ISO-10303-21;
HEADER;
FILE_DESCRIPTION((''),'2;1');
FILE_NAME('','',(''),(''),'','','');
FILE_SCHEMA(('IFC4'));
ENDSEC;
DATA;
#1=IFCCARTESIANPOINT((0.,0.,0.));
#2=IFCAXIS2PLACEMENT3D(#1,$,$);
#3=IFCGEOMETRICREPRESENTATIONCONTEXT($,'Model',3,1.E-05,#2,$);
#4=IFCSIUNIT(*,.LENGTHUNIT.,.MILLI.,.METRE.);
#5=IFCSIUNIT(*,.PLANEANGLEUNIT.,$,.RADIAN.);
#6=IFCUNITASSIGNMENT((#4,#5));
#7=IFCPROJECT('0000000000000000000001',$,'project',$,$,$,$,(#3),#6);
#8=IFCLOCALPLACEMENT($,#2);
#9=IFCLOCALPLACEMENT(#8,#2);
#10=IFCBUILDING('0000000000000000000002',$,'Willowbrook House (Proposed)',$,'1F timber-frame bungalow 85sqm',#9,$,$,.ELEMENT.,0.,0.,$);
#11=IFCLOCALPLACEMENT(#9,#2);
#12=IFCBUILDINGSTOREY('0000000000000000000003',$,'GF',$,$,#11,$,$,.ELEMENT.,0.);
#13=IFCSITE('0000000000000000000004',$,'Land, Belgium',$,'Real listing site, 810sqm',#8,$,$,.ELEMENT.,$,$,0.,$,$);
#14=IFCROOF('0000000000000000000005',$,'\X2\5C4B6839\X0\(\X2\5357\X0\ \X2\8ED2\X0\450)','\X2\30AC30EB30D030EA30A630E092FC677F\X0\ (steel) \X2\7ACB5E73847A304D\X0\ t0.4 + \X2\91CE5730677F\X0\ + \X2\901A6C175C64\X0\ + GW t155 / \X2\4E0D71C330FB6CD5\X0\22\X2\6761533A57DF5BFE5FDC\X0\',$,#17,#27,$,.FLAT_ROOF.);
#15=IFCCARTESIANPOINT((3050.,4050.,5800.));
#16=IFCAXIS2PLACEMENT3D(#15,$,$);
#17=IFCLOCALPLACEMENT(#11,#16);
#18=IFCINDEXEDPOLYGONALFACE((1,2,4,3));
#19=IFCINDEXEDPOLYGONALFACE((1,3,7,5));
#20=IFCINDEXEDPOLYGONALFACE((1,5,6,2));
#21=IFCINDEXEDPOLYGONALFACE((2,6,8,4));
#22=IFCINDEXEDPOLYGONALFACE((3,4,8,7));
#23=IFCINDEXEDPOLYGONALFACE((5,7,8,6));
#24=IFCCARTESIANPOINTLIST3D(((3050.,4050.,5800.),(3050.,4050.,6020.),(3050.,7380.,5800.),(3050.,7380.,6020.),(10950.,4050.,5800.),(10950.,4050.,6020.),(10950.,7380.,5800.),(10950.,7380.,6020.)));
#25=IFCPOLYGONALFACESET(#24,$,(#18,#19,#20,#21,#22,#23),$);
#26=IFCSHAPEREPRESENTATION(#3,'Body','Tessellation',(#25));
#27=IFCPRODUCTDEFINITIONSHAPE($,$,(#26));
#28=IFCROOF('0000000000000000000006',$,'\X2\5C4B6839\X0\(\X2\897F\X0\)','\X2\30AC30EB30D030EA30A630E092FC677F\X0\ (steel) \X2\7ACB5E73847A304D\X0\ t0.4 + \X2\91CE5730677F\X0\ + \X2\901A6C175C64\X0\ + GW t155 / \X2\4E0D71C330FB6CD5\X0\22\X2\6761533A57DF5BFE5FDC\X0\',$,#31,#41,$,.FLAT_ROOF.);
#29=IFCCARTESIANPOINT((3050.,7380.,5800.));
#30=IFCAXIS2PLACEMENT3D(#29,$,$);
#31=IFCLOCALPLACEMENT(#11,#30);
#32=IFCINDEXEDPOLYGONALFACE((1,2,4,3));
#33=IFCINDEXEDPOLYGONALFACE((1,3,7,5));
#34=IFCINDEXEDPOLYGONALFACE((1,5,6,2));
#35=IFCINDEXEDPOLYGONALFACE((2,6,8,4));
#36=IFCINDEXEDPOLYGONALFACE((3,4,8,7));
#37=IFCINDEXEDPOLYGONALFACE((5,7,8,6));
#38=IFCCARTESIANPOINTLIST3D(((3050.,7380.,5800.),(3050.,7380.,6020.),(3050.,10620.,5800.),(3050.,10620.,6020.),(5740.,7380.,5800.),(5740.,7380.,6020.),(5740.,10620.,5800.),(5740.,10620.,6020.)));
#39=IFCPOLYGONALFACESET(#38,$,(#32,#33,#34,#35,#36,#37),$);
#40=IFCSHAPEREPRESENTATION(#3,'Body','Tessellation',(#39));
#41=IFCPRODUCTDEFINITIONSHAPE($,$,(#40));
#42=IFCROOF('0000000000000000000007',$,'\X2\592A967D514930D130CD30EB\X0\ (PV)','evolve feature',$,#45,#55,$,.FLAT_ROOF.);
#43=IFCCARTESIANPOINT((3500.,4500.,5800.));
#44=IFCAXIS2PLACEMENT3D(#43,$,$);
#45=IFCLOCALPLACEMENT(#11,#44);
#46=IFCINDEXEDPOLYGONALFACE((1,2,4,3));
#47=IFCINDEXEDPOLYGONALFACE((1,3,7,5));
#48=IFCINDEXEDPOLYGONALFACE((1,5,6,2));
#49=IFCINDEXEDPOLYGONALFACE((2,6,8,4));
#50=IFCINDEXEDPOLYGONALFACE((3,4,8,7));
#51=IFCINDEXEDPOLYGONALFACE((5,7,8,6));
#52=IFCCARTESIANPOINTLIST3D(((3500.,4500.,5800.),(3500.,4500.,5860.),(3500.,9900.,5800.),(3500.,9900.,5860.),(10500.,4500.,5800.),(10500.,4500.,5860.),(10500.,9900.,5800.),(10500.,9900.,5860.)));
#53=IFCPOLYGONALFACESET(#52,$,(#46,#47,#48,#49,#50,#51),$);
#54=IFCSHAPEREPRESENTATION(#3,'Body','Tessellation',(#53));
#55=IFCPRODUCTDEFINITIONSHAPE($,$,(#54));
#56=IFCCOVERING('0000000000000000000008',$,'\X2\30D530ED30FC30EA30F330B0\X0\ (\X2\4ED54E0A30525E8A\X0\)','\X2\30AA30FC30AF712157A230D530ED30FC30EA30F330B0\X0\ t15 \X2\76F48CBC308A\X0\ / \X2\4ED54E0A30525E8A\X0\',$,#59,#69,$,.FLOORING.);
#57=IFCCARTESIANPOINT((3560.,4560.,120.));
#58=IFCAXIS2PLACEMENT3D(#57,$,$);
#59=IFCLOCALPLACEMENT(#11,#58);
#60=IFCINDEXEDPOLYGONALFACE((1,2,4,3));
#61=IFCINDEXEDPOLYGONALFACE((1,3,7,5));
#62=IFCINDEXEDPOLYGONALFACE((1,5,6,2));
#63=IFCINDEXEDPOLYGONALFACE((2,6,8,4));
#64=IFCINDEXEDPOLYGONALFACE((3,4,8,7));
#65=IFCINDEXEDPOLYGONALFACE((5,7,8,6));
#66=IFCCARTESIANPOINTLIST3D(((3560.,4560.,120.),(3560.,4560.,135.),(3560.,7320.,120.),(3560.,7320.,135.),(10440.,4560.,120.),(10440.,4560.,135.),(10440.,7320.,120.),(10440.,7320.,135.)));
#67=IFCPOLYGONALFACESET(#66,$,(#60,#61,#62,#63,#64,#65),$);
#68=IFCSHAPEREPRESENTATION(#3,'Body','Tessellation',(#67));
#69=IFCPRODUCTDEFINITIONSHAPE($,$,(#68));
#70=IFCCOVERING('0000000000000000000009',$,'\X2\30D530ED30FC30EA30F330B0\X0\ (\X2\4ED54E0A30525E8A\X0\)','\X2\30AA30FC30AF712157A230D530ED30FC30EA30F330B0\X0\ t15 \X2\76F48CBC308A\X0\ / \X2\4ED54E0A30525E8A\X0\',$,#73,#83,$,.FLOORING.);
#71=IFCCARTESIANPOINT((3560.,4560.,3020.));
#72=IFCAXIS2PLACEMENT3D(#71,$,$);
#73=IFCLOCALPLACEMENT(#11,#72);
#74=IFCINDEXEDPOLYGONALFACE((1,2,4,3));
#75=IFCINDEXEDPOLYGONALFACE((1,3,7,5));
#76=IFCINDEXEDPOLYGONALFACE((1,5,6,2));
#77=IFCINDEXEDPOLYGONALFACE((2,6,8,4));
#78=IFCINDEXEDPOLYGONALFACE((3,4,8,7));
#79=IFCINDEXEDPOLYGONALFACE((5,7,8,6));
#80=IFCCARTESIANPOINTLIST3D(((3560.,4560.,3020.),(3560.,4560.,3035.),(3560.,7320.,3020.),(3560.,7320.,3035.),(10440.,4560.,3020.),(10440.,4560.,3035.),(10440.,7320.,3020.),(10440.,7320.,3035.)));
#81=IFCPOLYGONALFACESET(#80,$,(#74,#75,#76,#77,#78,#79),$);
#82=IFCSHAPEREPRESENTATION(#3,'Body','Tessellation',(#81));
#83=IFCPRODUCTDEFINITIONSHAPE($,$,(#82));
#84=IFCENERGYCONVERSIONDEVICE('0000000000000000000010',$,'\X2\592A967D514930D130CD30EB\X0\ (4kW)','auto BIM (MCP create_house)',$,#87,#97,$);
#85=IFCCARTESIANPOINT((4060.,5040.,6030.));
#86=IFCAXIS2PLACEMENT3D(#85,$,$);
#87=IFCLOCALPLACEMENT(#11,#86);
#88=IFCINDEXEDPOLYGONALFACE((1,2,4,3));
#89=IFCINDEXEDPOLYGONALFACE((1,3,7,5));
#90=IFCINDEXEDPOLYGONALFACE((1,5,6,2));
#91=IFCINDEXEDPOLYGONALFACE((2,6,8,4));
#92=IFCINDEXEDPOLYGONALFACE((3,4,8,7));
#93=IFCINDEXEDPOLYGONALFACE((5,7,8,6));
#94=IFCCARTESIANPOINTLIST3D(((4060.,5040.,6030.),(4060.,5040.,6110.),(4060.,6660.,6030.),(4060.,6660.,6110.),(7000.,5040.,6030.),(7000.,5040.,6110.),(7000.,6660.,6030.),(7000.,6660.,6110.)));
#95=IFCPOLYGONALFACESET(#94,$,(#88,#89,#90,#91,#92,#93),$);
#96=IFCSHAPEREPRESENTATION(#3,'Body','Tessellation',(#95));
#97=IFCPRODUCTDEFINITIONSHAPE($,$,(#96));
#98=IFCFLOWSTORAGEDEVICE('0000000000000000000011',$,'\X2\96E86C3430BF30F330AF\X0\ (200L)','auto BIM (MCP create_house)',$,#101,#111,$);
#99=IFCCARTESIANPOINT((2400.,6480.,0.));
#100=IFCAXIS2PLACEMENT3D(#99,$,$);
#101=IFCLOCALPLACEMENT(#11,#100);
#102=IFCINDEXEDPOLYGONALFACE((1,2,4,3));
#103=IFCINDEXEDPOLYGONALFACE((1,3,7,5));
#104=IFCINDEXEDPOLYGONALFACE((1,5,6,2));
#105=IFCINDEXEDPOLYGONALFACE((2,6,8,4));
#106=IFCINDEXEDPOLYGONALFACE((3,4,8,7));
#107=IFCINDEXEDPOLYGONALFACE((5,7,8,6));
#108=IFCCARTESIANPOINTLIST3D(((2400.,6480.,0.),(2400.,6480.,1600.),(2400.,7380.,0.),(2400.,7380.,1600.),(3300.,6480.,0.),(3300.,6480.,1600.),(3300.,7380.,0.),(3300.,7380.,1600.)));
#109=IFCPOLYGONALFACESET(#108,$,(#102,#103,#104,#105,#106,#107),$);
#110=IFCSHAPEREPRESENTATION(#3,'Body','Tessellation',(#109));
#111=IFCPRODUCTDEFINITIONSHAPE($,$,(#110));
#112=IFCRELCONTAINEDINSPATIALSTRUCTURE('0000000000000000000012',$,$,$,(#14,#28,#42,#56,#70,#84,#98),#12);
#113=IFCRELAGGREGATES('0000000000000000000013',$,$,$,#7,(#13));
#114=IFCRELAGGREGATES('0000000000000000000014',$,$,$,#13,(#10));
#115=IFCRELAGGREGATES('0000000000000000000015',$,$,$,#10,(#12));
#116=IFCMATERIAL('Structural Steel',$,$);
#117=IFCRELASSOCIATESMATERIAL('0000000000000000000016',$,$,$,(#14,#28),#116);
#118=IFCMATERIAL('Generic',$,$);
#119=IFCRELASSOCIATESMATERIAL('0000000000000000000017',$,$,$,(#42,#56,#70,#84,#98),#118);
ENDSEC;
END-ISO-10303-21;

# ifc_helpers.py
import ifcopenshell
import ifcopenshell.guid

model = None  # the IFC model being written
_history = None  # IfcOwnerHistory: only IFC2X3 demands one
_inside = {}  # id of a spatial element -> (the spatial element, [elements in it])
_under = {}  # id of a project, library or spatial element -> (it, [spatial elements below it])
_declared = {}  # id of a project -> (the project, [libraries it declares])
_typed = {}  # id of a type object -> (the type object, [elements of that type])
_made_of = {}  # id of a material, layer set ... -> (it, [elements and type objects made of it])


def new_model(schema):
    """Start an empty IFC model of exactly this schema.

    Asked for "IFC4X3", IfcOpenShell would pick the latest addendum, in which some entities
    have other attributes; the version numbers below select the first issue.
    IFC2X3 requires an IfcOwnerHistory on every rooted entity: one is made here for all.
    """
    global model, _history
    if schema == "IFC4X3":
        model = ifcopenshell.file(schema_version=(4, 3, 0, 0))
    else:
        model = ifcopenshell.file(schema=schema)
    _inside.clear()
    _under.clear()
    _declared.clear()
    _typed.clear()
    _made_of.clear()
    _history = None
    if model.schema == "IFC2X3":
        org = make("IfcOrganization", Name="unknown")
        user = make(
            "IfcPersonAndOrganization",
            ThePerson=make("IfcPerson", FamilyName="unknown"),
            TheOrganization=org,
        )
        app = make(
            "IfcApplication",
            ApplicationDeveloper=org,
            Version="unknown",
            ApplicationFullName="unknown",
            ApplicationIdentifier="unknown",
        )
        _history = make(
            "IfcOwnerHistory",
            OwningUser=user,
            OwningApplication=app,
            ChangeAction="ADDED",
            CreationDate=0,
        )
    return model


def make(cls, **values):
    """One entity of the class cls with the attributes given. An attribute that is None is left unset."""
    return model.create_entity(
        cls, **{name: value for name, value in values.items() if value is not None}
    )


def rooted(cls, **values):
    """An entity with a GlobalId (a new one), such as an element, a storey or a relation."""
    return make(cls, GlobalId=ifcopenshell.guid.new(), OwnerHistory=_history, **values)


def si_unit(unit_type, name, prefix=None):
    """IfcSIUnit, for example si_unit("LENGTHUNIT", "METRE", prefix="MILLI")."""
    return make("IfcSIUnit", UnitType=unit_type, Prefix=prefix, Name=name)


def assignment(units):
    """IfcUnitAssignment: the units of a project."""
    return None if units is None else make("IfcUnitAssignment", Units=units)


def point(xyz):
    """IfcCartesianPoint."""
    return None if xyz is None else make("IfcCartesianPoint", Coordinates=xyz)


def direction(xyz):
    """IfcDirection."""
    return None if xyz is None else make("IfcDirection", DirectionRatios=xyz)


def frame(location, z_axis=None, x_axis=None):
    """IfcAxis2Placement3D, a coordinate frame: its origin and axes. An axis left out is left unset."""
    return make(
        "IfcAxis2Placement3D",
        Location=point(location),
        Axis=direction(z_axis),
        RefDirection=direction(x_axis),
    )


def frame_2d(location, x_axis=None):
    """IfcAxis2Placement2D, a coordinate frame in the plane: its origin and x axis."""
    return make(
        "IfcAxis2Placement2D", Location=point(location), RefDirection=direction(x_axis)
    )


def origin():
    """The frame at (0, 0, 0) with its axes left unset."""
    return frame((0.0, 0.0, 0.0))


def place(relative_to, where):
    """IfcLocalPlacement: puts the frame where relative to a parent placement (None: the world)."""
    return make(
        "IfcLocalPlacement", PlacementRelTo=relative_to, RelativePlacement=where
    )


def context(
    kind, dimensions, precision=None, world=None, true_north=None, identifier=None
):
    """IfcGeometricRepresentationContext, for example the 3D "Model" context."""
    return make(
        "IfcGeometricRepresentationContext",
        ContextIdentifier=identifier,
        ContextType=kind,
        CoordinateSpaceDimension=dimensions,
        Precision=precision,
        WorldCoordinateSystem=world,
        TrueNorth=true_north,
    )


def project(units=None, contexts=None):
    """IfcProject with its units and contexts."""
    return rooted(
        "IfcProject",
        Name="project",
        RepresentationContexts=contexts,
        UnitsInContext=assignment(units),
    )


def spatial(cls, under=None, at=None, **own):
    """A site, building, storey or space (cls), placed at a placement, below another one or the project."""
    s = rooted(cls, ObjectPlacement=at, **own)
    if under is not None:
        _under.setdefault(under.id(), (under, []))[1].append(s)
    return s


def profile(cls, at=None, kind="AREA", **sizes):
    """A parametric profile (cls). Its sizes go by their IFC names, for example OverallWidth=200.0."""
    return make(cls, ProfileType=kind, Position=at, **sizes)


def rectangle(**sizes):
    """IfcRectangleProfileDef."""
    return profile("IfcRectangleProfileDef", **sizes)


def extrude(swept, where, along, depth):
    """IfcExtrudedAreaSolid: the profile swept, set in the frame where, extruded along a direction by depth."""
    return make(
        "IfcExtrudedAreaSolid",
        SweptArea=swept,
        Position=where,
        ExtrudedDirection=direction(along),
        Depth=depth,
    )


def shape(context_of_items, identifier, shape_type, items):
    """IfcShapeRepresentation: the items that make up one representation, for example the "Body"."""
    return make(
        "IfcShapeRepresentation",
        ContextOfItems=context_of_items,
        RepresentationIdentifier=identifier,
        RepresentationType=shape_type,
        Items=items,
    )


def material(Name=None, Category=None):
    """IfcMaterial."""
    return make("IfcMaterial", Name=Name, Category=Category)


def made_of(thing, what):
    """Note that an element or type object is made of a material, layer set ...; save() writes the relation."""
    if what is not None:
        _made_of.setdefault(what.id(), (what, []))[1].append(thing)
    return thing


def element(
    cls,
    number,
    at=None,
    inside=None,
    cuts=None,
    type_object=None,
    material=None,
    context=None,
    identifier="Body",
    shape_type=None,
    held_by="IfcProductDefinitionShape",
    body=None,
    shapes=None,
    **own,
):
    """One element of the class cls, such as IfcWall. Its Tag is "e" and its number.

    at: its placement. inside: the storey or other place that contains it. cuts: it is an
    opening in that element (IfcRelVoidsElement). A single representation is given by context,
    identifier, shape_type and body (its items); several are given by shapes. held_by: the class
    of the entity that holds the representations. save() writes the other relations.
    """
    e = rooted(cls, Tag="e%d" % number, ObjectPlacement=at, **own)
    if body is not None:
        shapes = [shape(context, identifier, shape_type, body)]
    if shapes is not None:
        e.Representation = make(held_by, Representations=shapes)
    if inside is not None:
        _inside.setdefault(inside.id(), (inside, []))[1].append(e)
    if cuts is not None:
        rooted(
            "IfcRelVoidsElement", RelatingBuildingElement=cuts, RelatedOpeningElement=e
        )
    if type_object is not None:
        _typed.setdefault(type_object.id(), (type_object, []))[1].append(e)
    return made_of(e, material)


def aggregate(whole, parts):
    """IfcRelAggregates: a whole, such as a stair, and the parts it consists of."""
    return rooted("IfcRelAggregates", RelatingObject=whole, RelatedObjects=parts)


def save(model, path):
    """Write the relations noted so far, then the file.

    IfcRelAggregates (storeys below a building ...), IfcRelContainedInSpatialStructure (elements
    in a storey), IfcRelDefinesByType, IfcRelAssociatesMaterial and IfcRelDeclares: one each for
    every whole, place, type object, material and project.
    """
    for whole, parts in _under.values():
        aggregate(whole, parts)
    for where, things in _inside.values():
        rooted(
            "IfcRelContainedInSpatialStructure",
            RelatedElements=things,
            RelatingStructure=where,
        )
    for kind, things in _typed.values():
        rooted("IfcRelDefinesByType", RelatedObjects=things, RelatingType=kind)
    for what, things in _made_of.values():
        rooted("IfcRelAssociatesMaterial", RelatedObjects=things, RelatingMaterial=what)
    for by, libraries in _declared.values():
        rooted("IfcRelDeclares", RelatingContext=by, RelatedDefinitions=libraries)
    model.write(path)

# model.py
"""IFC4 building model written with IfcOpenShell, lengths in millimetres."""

from ifc_helpers import new_model, si_unit, frame, frame_2d, origin, place, context, project, spatial, rectangle, extrude, material, element, save


model = new_model("IFC4")

# Units and contexts
model_context = context("Model", 3, precision=1e-05, world=origin())
ifc_project = project(units=[si_unit("LENGTHUNIT", "METRE", prefix="MILLI"), si_unit("PLANEANGLEUNIT", "RADIAN")], contexts=[model_context])

# Site, building, storey
site_placement = place(None, origin())
site = spatial("IfcSite", under=ifc_project, at=site_placement, Name="Land, Belgium", ObjectType="Real listing site, 810sqm", CompositionType="ELEMENT", RefElevation=0.0)
building_placement = place(site_placement, origin())
building = spatial("IfcBuilding", under=site, at=building_placement, Name="Willowbrook House (Proposed)", ObjectType="1F timber-frame bungalow 85sqm", CompositionType="ELEMENT", ElevationOfRefHeight=0.0, ElevationOfTerrain=0.0)
storey_placement = place(building_placement, origin())
storey = spatial("IfcBuildingStorey", under=building, at=storey_placement, Name="GF", CompositionType="ELEMENT", Elevation=0.0)

# Shared definitions
ifc_material_1 = material(Name="Generic")

# Roofs
ifc_material_2 = material(Name="Structural Steel")
roof_1_placement = place(storey_placement, frame((3050.0, 4050.0, 5800.0)))
element("IfcRoof", 1, at=roof_1_placement, inside=storey, material=ifc_material_2, Name="屋根(南 軒450)", Description="ガルバリウム鋼板 (steel) 立平葺き t0.4 + 野地板 + 通気層 + GW t155 / 不燃・法22条区域対応", PredefinedType="FLAT_ROOF", context=model_context, shape_type="SweptSolid", body=[
    extrude(rectangle(XDim=7900.0, YDim=3330.0, at=frame_2d((3950.0, 1665.0))), frame((3050.0, 4050.0, 5800.0)), (0.0, 0.0, 1.0), 220.0),
])
roof_2_placement = place(storey_placement, frame((3050.0, 7380.0, 5800.0)))
element("IfcRoof", 2, at=roof_2_placement, inside=storey, material=ifc_material_2, Name="屋根(西)", Description="ガルバリウム鋼板 (steel) 立平葺き t0.4 + 野地板 + 通気層 + GW t155 / 不燃・法22条区域対応", PredefinedType="FLAT_ROOF", context=model_context, shape_type="SweptSolid", body=[
    extrude(rectangle(XDim=2690.0, YDim=3240.0, at=frame_2d((1345.0, 1620.0))), frame((3050.0, 7380.0, 5800.0)), (0.0, 0.0, 1.0), 220.0),
])
roof_3_placement = place(storey_placement, frame((3500.0, 4500.0, 5800.0)))
element("IfcRoof", 3, at=roof_3_placement, inside=storey, material=ifc_material_1, Name="太陽光パネル (PV)", Description="evolve feature", PredefinedType="FLAT_ROOF", context=model_context, shape_type="SweptSolid", body=[
    extrude(rectangle(XDim=7000.0, YDim=5400.0, at=frame_2d((3500.0, 2700.0))), frame((3500.0, 4500.0, 5800.0)), (0.0, 0.0, 1.0), 60.0),
])

# Coverings
covering_1_placement = place(storey_placement, frame((3560.0, 4560.0, 120.0)))
element("IfcCovering", 4, at=covering_1_placement, inside=storey, material=ifc_material_1, Name="フローリング (仕上げ床)", Description="オーク無垢フローリング t15 直貼り / 仕上げ床", PredefinedType="FLOORING", context=model_context, shape_type="SweptSolid", body=[
    extrude(rectangle(XDim=6880.0, YDim=2760.0, at=frame_2d((3440.0, 1380.0))), frame((3560.0, 4560.0, 120.0)), (0.0, 0.0, 1.0), 15.0),
])
covering_2_placement = place(storey_placement, frame((3560.0, 4560.0, 3020.0)))
element("IfcCovering", 5, at=covering_2_placement, inside=storey, material=ifc_material_1, Name="フローリング (仕上げ床)", Description="オーク無垢フローリング t15 直貼り / 仕上げ床", PredefinedType="FLOORING", context=model_context, shape_type="SweptSolid", body=[
    extrude(rectangle(XDim=6880.0, YDim=2760.0, at=frame_2d((3440.0, 1380.0))), frame((3560.0, 4560.0, 3020.0)), (0.0, 0.0, 1.0), 15.0),
])

# Energy conversion device
energy_conversion_device_placement = place(storey_placement, frame((4060.0, 5040.0, 6030.0)))
element("IfcEnergyConversionDevice", 6, at=energy_conversion_device_placement, inside=storey, material=ifc_material_1, Name="太陽光パネル (4kW)", Description="auto BIM (MCP create_house)", context=model_context, shape_type="SweptSolid", body=[
    extrude(rectangle(XDim=2940.0, YDim=1620.0, at=frame_2d((1470.0, 810.0))), frame((4060.0, 5040.0, 6030.0)), (0.0, 0.0, 1.0), 80.0),
])

# Flow storage device
flow_storage_device_placement = place(storey_placement, frame((2400.0, 6480.0, 0.0)))
element("IfcFlowStorageDevice", 7, at=flow_storage_device_placement, inside=storey, material=ifc_material_1, Name="雨水タンク (200L)", Description="auto BIM (MCP create_house)", context=model_context, shape_type="SweptSolid", body=[
    extrude(rectangle(XDim=900.0, YDim=900.0, at=frame_2d((450.0, 450.0))), frame((2400.0, 6480.0, 0.0)), (0.0, 0.0, 1.0), 1600.0),
])

save(model, "model.ifc")
